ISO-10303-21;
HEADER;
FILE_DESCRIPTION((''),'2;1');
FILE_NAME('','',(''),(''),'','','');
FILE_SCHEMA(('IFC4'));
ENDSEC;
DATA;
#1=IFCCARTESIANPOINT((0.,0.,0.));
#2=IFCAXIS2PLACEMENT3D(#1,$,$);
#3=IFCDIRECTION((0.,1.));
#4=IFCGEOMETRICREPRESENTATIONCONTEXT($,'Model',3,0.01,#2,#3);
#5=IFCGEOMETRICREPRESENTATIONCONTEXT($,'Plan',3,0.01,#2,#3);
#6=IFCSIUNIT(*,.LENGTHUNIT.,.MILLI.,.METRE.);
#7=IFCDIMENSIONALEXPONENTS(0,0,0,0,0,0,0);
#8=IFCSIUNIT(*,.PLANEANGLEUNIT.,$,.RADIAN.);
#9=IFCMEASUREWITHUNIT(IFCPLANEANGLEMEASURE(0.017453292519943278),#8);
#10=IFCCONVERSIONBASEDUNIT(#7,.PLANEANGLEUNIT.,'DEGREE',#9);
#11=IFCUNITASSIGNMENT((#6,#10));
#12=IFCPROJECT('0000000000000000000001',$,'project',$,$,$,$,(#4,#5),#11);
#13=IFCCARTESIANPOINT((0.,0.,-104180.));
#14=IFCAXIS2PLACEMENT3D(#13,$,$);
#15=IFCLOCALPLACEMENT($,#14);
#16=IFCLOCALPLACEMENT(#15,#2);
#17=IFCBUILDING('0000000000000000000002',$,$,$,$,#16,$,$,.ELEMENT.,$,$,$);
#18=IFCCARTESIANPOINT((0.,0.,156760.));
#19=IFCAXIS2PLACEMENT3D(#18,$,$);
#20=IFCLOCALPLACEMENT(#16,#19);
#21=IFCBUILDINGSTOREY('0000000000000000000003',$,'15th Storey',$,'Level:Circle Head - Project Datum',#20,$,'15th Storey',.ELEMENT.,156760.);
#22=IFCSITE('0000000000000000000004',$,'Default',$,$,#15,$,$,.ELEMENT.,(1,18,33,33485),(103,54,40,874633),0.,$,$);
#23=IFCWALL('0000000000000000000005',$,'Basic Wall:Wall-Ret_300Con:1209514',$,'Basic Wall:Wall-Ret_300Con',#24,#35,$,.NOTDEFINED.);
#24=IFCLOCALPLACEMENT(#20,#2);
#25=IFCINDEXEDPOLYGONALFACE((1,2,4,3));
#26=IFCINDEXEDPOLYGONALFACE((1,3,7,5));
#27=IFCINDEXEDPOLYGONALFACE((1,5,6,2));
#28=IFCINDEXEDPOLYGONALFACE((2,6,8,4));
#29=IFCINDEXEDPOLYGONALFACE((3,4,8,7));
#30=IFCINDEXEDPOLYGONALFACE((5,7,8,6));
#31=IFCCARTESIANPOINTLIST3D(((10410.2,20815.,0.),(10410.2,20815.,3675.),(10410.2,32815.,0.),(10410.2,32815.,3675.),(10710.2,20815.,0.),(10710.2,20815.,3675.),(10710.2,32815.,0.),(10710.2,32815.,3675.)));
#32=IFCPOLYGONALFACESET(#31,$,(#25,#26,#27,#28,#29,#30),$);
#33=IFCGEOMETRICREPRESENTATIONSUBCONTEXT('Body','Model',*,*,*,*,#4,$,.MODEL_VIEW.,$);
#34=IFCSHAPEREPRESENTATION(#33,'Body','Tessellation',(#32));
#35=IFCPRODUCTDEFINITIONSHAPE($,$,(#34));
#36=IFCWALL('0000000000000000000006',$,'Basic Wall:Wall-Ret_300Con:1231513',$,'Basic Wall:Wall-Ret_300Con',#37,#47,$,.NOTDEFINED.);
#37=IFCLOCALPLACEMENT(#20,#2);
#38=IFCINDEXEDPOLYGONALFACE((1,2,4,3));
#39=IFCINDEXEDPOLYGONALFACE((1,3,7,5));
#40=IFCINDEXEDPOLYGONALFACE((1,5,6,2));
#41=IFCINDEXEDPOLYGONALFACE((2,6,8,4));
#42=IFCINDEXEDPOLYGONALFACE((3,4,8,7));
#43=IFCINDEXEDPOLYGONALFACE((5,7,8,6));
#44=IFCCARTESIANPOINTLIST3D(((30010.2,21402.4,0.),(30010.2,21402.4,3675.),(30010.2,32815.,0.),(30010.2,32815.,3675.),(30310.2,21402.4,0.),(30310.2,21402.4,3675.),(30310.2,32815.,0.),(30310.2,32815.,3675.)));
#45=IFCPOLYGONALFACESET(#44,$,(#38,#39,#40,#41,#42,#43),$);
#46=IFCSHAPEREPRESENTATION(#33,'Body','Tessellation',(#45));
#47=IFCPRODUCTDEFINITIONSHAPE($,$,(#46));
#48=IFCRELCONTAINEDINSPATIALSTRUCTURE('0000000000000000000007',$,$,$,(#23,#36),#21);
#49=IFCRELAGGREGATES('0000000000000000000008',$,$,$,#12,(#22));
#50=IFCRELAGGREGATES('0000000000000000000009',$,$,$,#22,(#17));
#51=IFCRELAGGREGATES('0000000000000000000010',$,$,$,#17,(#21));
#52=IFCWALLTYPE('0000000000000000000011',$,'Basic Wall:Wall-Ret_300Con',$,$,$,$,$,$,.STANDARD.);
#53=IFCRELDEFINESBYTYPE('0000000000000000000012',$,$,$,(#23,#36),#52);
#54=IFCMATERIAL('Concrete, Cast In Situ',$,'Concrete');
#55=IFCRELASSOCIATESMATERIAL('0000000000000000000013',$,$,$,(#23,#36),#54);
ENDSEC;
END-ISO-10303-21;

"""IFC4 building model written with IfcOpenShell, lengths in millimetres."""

from ifc_helpers import new_model, entity, si_unit, converted_unit, direction, frame, origin, place, context, subcontext, project, spatial, indexed_curve, outline, extrude, material, type_object, element, save


model = new_model("IFC4")

# Units and contexts
model_context = context("Model", 3, precision=0.01, world=origin(), true_north=direction((0.0, 1.0)))
plan_context = context("Plan", 3, precision=0.01, world=origin(), true_north=direction((0.0, 1.0)))
body_context = subcontext(model_context, "Body", "Model", "MODEL_VIEW")
ifc_project = project(units=[si_unit("LENGTHUNIT", "METRE", prefix="MILLI"), converted_unit("PLANEANGLEUNIT", "DEGREE", entity("IfcPlaneAngleMeasure", 0.017453292519943278), si_unit("PLANEANGLEUNIT", "RADIAN"), dimensions=[0, 0, 0, 0, 0, 0, 0])], contexts=[model_context, plan_context])

# Site, building, storey
site_placement = place(None, frame((0.0, 0.0, -104180.0)))
site = spatial("IfcSite", under=ifc_project, at=site_placement, Name="Default", CompositionType="ELEMENT", RefLatitude=(1, 18, 33, 33485), RefLongitude=(103, 54, 40, 874633), RefElevation=0.0)
building_placement = place(site_placement, origin())
building = spatial("IfcBuilding", under=site, at=building_placement, CompositionType="ELEMENT")
storey_placement = place(building_placement, frame((0.0, 0.0, 156760.0)))
storey = spatial("IfcBuildingStorey", under=building, at=storey_placement, Name="15th Storey", ObjectType="Level:Circle Head - Project Datum", LongName="15th Storey", CompositionType="ELEMENT", Elevation=156760.0)

# Walls
ifc_material_1 = material(Name="Concrete, Cast In Situ", Category="Concrete")
wall_type = type_object("IfcWallType", Name="Basic Wall:Wall-Ret_300Con", PredefinedType="STANDARD")
wall_1_placement = place(storey_placement, frame((10560.2, 32815.0, 0.0), z_axis=(0.0, 0.0, 1.0), x_axis=(0.0, -1.0, 0.0)))
element("IfcWall", 1, at=wall_1_placement, inside=storey, type_object=wall_type, material=ifc_material_1, Name="Basic Wall:Wall-Ret_300Con:1209514", ObjectType="Basic Wall:Wall-Ret_300Con", PredefinedType="NOTDEFINED", context=body_context, shape_type="SweptSolid", body=[
    extrude(outline(indexed_curve([(12000.0, 150.0), (0.0, 150.0), (0.0, -150.0), (12000.0, -150.0), (12000.0, 150.0)], self_intersect=False)), origin(), (0.0, 0.0, 1.0), 3675.0),
])
wall_2_placement = place(storey_placement, frame((30160.2, 32815.0, 0.0), z_axis=(0.0, 0.0, 1.0), x_axis=(0.0, -1.0, 0.0)))
element("IfcWall", 2, at=wall_2_placement, inside=storey, type_object=wall_type, material=ifc_material_1, Name="Basic Wall:Wall-Ret_300Con:1231513", ObjectType="Basic Wall:Wall-Ret_300Con", PredefinedType="NOTDEFINED", context=body_context, shape_type="SweptSolid", body=[
    extrude(outline(indexed_curve([(11412.6, 150.0), (0.0, 150.0), (0.0, -150.0), (11412.6, -150.0), (11412.6, 150.0)], self_intersect=False)), origin(), (0.0, 0.0, 1.0), 3675.0),
])

save(model, "model.ifc")
